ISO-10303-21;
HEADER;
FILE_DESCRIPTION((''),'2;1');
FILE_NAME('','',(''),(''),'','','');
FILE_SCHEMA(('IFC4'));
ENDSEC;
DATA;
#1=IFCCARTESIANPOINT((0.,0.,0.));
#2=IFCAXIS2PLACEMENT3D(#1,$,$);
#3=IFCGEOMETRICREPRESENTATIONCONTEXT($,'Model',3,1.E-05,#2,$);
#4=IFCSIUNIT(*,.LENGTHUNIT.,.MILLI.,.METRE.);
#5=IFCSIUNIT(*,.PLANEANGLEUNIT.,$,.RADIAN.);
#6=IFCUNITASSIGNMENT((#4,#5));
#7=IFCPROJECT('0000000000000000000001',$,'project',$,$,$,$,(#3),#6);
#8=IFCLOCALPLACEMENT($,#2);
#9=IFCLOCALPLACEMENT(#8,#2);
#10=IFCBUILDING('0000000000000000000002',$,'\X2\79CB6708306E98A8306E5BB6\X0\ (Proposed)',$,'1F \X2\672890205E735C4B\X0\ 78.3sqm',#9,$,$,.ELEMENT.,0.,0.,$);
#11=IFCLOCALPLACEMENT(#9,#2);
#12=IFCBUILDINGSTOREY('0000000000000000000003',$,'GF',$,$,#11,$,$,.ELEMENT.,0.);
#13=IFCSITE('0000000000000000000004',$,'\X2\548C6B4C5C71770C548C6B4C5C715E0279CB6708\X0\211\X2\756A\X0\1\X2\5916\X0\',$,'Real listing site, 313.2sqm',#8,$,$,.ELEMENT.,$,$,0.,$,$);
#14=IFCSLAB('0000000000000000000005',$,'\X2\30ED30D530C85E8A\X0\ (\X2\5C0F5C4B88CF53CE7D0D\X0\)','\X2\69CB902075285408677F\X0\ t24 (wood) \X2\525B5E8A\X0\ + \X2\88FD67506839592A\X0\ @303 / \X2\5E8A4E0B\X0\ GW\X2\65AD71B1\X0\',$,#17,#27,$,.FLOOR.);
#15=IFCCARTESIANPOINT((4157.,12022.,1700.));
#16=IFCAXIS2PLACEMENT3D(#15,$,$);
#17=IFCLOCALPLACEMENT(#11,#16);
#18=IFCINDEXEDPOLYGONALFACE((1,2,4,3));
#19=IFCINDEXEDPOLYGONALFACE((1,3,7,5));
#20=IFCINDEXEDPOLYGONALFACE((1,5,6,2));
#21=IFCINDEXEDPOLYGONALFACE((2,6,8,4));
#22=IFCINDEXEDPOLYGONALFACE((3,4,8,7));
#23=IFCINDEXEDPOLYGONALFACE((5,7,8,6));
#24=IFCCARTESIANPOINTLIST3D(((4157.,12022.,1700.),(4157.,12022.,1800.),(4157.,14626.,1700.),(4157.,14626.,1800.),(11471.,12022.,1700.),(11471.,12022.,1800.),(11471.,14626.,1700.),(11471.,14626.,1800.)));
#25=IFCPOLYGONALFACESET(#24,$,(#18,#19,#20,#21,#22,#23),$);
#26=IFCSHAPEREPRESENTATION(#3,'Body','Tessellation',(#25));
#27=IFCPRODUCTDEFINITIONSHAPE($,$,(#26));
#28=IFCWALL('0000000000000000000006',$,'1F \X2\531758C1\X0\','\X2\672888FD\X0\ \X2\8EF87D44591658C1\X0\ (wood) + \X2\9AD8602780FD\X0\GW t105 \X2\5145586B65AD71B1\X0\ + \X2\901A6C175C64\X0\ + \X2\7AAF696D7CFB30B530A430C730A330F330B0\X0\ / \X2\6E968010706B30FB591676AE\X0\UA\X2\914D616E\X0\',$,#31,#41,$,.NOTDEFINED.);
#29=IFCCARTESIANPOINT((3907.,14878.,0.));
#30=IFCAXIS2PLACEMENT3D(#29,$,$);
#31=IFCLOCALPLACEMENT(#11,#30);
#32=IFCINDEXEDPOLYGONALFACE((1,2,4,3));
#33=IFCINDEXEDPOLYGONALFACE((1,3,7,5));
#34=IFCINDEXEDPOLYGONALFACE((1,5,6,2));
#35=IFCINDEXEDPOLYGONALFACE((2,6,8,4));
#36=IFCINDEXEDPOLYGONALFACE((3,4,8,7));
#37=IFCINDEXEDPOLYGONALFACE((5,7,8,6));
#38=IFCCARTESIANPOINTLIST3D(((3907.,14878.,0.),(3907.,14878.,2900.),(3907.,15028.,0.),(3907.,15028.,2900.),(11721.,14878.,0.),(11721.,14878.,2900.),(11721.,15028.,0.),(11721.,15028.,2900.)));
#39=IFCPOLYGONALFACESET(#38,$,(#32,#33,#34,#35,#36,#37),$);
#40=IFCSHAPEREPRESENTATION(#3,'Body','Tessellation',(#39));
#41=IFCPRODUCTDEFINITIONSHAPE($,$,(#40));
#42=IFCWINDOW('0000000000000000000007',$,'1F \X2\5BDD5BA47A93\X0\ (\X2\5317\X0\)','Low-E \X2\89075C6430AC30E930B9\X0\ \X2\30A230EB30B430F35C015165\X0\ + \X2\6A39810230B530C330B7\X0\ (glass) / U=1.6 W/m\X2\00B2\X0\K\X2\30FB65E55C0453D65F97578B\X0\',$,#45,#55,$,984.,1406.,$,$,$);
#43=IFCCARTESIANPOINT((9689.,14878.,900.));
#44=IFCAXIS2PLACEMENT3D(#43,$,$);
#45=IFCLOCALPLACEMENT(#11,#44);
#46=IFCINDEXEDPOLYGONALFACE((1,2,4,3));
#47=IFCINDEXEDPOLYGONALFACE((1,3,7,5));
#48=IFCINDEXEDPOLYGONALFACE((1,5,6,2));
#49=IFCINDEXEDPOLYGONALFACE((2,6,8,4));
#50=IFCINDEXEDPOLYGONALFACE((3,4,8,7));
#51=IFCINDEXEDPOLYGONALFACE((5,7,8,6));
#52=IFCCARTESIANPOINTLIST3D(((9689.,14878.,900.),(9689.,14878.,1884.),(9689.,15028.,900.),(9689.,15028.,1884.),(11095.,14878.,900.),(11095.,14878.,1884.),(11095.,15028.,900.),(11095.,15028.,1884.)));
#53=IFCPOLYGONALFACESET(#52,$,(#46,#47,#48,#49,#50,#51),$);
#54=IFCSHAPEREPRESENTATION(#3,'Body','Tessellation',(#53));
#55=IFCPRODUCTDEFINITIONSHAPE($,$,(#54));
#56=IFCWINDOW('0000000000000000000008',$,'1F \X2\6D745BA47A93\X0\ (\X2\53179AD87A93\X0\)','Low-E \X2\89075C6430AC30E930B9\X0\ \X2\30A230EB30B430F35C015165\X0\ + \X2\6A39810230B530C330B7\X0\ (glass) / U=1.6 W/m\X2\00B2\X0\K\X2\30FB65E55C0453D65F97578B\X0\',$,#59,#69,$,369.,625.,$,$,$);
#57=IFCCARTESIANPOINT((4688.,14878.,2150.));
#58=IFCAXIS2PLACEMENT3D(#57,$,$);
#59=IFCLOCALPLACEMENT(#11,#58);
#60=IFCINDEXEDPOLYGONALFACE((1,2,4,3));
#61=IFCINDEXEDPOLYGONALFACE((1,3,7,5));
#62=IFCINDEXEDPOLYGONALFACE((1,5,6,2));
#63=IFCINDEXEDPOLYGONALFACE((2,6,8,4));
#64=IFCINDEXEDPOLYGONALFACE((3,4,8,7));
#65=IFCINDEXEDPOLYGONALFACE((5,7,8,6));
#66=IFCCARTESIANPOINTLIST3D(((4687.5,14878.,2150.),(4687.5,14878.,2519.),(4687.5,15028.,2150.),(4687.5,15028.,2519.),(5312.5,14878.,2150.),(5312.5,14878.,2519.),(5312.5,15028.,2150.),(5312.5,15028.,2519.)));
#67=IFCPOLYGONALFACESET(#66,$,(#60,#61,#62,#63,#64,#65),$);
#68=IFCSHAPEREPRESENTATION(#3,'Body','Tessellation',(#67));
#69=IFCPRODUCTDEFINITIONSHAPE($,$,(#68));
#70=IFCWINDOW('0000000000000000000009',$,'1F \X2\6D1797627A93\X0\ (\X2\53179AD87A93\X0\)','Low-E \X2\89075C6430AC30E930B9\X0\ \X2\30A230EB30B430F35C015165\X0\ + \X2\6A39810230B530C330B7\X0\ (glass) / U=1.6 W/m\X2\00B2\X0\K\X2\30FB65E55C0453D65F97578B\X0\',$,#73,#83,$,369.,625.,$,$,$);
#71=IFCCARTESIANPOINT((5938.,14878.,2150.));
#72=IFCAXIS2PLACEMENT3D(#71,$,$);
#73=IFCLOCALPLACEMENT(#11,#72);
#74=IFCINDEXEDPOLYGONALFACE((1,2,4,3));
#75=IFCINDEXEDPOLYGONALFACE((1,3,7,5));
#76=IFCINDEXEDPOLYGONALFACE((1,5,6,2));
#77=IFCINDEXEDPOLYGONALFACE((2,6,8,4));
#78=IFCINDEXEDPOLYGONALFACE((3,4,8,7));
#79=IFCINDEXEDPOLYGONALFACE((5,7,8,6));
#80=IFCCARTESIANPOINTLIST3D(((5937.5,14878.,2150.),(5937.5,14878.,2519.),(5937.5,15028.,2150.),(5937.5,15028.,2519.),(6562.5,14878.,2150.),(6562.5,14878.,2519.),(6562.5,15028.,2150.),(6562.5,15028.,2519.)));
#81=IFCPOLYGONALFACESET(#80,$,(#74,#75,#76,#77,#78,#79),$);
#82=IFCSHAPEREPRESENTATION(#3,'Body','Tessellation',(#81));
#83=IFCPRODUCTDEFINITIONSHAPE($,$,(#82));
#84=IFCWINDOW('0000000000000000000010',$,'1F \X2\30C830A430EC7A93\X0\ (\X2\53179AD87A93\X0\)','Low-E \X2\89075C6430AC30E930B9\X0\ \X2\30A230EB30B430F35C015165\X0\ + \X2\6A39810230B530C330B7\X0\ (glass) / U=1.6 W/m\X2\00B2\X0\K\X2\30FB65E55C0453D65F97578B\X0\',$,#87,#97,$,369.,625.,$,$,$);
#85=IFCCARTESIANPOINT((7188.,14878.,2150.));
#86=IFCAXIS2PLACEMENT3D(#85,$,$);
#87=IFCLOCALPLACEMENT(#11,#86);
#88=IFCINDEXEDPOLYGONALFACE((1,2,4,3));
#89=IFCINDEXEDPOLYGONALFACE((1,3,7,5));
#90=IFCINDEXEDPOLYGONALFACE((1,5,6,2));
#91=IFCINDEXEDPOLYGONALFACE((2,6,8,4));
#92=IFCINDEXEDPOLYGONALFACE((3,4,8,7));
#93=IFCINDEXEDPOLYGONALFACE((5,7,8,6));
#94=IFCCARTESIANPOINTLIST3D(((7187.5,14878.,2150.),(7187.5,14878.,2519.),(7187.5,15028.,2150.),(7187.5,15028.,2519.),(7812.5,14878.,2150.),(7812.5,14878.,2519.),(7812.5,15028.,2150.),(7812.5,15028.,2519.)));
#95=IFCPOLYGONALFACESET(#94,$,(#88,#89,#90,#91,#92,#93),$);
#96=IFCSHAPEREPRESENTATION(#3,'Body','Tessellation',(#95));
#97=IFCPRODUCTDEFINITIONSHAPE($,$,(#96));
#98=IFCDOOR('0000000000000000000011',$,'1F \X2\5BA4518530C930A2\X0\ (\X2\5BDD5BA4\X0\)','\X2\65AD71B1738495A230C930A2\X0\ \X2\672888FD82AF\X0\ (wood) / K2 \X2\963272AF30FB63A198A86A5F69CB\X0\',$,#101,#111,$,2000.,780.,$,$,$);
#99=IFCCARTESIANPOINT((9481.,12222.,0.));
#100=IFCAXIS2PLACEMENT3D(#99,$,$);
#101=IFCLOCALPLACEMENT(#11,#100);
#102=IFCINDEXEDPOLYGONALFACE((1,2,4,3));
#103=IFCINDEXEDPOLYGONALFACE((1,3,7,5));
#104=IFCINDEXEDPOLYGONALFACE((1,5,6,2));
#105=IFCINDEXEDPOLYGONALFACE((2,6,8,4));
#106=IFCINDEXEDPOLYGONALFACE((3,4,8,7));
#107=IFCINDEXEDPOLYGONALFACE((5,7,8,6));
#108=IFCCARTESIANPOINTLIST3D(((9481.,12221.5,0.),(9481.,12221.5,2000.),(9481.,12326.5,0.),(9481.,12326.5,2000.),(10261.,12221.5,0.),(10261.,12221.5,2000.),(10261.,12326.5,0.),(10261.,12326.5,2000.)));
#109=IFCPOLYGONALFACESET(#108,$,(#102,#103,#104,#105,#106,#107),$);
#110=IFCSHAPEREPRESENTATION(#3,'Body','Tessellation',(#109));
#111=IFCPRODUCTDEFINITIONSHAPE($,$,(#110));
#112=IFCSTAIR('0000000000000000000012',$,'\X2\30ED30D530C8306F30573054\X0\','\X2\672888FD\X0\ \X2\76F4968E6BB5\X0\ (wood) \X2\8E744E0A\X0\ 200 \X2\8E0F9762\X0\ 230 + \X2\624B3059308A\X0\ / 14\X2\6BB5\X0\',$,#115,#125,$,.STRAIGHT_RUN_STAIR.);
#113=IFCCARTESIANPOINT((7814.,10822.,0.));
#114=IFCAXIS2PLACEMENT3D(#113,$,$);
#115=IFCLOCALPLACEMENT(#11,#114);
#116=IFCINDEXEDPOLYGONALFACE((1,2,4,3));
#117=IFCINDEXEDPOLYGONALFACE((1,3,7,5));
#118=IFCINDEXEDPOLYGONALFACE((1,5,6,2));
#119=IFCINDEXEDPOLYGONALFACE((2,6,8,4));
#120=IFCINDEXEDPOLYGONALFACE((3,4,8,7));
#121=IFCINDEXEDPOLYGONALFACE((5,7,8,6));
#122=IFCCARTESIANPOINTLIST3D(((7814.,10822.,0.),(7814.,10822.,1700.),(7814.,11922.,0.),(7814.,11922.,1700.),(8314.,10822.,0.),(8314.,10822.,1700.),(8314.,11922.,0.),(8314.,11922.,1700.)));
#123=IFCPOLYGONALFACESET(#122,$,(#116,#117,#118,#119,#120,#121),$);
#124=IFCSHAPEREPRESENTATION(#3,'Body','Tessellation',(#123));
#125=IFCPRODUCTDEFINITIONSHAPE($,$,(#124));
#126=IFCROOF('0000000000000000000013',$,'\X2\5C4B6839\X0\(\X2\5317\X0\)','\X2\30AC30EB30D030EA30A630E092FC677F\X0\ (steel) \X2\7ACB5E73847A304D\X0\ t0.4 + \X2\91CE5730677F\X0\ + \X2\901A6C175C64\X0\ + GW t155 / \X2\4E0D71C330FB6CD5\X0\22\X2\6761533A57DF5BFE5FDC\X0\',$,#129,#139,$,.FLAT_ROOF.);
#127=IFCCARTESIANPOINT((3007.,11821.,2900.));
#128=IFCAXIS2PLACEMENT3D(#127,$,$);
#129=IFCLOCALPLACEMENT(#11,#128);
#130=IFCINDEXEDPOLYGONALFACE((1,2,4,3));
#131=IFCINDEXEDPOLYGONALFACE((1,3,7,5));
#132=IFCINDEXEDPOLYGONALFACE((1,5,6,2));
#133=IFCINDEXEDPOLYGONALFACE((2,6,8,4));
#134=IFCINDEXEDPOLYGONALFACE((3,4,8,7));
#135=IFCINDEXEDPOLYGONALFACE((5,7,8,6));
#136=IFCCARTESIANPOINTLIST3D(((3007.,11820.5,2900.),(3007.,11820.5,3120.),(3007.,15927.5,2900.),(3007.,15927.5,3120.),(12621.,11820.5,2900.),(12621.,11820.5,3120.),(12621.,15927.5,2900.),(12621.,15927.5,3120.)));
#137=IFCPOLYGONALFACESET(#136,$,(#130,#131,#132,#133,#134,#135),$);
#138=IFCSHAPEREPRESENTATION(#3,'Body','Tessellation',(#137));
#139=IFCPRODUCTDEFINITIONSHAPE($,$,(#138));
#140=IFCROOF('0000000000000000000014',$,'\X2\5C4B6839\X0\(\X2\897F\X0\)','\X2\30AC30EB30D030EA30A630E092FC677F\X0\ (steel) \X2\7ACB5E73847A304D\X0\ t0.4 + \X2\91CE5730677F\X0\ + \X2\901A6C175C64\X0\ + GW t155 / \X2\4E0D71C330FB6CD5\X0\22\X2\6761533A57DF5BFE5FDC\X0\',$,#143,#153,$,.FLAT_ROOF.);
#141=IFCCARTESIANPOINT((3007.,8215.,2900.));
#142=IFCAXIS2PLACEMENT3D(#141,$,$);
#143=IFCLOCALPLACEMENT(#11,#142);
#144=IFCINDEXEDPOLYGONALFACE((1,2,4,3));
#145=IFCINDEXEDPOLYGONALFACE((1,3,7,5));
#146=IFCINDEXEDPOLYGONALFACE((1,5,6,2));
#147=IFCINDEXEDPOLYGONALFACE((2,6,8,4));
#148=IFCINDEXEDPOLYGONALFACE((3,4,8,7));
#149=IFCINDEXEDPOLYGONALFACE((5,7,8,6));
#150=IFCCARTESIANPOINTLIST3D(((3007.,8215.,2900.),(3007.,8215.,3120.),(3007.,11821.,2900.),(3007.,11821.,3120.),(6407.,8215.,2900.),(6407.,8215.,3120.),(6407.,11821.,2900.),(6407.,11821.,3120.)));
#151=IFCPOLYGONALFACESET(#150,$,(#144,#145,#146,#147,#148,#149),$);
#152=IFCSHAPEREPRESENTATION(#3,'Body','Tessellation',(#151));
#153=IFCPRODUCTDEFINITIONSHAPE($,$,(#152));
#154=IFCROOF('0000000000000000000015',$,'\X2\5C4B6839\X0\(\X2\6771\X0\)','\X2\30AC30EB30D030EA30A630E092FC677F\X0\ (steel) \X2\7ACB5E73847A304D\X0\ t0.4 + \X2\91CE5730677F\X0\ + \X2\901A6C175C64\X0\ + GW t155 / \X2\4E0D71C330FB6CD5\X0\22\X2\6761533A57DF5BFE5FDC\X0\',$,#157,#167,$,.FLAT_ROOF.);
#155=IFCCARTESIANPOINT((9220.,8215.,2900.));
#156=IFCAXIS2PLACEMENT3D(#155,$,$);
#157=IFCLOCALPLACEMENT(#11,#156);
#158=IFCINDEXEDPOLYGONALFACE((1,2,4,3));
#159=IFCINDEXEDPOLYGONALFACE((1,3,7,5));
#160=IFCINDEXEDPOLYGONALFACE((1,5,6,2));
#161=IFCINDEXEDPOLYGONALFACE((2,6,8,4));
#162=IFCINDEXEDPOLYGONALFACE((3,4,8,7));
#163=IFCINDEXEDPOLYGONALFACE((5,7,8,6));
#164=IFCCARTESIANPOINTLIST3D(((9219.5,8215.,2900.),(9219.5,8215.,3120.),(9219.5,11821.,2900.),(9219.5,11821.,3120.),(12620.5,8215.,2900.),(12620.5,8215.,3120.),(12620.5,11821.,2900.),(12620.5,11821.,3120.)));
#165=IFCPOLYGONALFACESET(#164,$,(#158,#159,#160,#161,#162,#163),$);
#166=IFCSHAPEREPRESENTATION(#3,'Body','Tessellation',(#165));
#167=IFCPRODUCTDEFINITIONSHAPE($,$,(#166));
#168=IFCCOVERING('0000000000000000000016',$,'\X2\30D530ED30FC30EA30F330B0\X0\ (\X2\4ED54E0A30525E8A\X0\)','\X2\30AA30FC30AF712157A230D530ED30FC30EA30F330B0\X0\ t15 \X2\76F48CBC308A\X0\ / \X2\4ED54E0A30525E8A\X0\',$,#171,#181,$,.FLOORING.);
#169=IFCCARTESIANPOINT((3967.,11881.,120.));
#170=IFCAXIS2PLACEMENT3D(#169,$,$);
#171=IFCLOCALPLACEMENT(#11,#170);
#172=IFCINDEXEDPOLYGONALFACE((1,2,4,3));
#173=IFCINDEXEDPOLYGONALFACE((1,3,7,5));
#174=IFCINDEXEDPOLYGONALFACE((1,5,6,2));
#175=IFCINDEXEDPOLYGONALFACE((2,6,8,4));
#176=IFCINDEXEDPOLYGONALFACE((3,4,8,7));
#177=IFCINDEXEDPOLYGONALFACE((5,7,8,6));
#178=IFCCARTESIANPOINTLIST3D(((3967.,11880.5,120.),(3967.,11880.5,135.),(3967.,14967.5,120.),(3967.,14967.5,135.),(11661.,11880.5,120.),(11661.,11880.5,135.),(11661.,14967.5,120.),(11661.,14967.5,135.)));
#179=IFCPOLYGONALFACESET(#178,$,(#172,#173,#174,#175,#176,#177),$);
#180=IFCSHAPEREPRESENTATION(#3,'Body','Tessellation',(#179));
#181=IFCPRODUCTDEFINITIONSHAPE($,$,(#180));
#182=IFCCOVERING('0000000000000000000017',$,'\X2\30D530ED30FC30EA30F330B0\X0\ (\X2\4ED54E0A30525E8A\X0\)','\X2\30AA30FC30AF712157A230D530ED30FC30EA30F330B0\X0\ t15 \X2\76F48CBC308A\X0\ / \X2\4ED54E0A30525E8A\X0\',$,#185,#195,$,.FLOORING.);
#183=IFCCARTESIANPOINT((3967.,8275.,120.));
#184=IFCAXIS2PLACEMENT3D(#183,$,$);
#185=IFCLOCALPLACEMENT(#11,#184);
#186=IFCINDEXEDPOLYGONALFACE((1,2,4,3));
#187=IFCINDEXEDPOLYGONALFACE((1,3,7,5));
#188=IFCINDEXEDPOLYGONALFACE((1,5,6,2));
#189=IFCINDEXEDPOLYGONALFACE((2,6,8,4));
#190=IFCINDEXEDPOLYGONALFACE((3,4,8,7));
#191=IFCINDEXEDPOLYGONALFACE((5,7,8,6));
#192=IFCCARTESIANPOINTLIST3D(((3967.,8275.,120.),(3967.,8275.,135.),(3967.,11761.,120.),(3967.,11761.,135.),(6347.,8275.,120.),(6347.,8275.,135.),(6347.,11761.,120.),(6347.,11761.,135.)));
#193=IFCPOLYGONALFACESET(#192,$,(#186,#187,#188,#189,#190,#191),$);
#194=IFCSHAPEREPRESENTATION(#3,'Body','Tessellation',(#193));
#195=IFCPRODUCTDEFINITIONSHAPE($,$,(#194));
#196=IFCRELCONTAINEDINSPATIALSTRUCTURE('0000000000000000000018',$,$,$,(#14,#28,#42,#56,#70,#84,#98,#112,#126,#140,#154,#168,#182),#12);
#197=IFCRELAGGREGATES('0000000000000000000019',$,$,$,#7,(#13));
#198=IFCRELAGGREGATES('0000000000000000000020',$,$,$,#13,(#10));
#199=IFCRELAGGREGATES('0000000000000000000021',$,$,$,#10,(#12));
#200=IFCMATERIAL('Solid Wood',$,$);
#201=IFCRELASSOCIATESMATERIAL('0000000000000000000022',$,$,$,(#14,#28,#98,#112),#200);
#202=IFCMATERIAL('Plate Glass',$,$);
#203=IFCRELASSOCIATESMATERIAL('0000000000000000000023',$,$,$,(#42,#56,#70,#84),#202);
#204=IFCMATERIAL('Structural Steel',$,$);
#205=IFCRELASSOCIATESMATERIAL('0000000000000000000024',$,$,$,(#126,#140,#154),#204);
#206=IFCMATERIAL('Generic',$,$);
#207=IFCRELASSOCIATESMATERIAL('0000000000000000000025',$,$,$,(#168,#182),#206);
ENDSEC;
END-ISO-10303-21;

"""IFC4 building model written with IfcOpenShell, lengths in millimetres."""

from ifc_helpers import new_model, si_unit, frame, frame_2d, origin, place, context, project, spatial, rectangle, extrude, material, element, fill, save


model = new_model("IFC4")

# Units and contexts
model_context = context("Model", 3, precision=1e-05, world=origin())
ifc_project = project(units=[si_unit("LENGTHUNIT", "METRE", prefix="MILLI"), si_unit("PLANEANGLEUNIT", "RADIAN")], contexts=[model_context])

# Site, building, storey
site_placement = place(None, origin())
site = spatial("IfcSite", under=ifc_project, at=site_placement, Name="和歌山県和歌山市秋月211番1外", ObjectType="Real listing site, 313.2sqm", CompositionType="ELEMENT", RefElevation=0.0)
building_placement = place(site_placement, origin())
building = spatial("IfcBuilding", under=site, at=building_placement, Name="秋月の風の家 (Proposed)", ObjectType="1F 木造平屋 78.3sqm", CompositionType="ELEMENT", ElevationOfRefHeight=0.0, ElevationOfTerrain=0.0)
storey_placement = place(building_placement, origin())
storey = spatial("IfcBuildingStorey", under=building, at=storey_placement, Name="GF", CompositionType="ELEMENT", Elevation=0.0)

# Slab
ifc_material_1 = material(Name="Solid Wood")
slab_1_placement = place(storey_placement, frame((4157.0, 12022.0, 1700.0)))
element("IfcSlab", 1, at=slab_1_placement, inside=storey, material=ifc_material_1, Name="ロフト床 (小屋裏収納)", Description="構造用合板 t24 (wood) 剛床 + 製材根太 @303 / 床下 GW断熱", PredefinedType="FLOOR", context=model_context, shape_type="SweptSolid", body=[
    extrude(rectangle(XDim=7314.0, YDim=2604.0, at=frame_2d((3657.0, 1302.0))), frame((4157.0, 12022.0, 1700.0)), (0.0, 0.0, 1.0), 100.0),
])

# Wall, openings, windows
wall_1_placement = place(storey_placement, frame((3907.0, 14878.0, 0.0)))
wall_1 = element("IfcWall", 2, at=wall_1_placement, inside=storey, material=ifc_material_1, Name="1F 北壁", Description="木製 軸組外壁 (wood) + 高性能GW t105 充填断熱 + 通気層 + 窯業系サイディング / 準耐火・外皮UA配慮", PredefinedType="NOTDEFINED", context=model_context, shape_type="SweptSolid", body=[
    extrude(rectangle(XDim=7814.0, YDim=150.0, at=frame_2d((3907.0, 75.0))), frame((3907.0, 14878.0, 0.0)), (0.0, 0.0, 1.0), 2900.0),
])
opening_1_placement = place(storey_placement, frame((9689.0, 14878.0, 900.0)))
opening_1 = element("IfcOpeningElement", 3, at=opening_1_placement, cuts=wall_1, PredefinedType="NOTDEFINED", context=model_context, shape_type="SweptSolid", body=[
    extrude(rectangle(XDim=1406.0, YDim=150.0, at=frame_2d((703.0, 75.0))), frame((9689.0, 14878.0, 900.0)), (0.0, 0.0, 1.0), 984.0),
])
opening_2_placement = place(storey_placement, frame((4688.0, 14878.0, 2150.0)))
opening_2 = element("IfcOpeningElement", 4, at=opening_2_placement, cuts=wall_1, PredefinedType="NOTDEFINED", context=model_context, shape_type="SweptSolid", body=[
    extrude(rectangle(XDim=625.0, YDim=150.0, at=frame_2d((312.0, 75.0))), frame((4688.0, 14878.0, 2150.0)), (0.0, 0.0, 1.0), 369.0),
])
opening_3_placement = place(storey_placement, frame((5938.0, 14878.0, 2150.0)))
opening_3 = element("IfcOpeningElement", 5, at=opening_3_placement, cuts=wall_1, PredefinedType="NOTDEFINED", context=model_context, shape_type="SweptSolid", body=[
    extrude(rectangle(XDim=625.0, YDim=150.0, at=frame_2d((312.0, 75.0))), frame((5938.0, 14878.0, 2150.0)), (0.0, 0.0, 1.0), 369.0),
])
opening_4_placement = place(storey_placement, frame((7188.0, 14878.0, 2150.0)))
opening_4 = element("IfcOpeningElement", 6, at=opening_4_placement, cuts=wall_1, PredefinedType="NOTDEFINED", context=model_context, shape_type="SweptSolid", body=[
    extrude(rectangle(XDim=625.0, YDim=150.0, at=frame_2d((312.0, 75.0))), frame((7188.0, 14878.0, 2150.0)), (0.0, 0.0, 1.0), 369.0),
])
ifc_material_2 = material(Name="Plate Glass")
window_1_placement = place(storey_placement, frame((9689.0, 14878.0, 900.0)))
window_1 = element("IfcWindow", 7, at=window_1_placement, inside=storey, material=ifc_material_2, Name="1F 寝室窓 (北)", Description="Low-E 複層ガラス アルゴン封入 + 樹脂サッシ (glass) / U=1.6 W/m²K・日射取得型", OverallHeight=984.0, OverallWidth=1406.0, context=model_context, shape_type="SweptSolid", body=[
    extrude(rectangle(XDim=1406.0, YDim=150.0, at=frame_2d((703.0, 75.0))), frame((9689.0, 14878.0, 900.0)), (0.0, 0.0, 1.0), 984.0),
])
fill(opening_1, window_1)
window_2_placement = place(storey_placement, frame((4688.0, 14878.0, 2150.0)))
window_2 = element("IfcWindow", 8, at=window_2_placement, inside=storey, material=ifc_material_2, Name="1F 浴室窓 (北高窓)", Description="Low-E 複層ガラス アルゴン封入 + 樹脂サッシ (glass) / U=1.6 W/m²K・日射取得型", OverallHeight=369.0, OverallWidth=625.0, context=model_context, shape_type="SweptSolid", body=[
    extrude(rectangle(XDim=625.0, YDim=150.0, at=frame_2d((312.0, 75.0))), frame((4688.0, 14878.0, 2150.0)), (0.0, 0.0, 1.0), 369.0),
])
fill(opening_2, window_2)
window_3_placement = place(storey_placement, frame((5938.0, 14878.0, 2150.0)))
window_3 = element("IfcWindow", 9, at=window_3_placement, inside=storey, material=ifc_material_2, Name="1F 洗面窓 (北高窓)", Description="Low-E 複層ガラス アルゴン封入 + 樹脂サッシ (glass) / U=1.6 W/m²K・日射取得型", OverallHeight=369.0, OverallWidth=625.0, context=model_context, shape_type="SweptSolid", body=[
    extrude(rectangle(XDim=625.0, YDim=150.0, at=frame_2d((312.0, 75.0))), frame((5938.0, 14878.0, 2150.0)), (0.0, 0.0, 1.0), 369.0),
])
fill(opening_3, window_3)
window_4_placement = place(storey_placement, frame((7188.0, 14878.0, 2150.0)))
window_4 = element("IfcWindow", 10, at=window_4_placement, inside=storey, material=ifc_material_2, Name="1F トイレ窓 (北高窓)", Description="Low-E 複層ガラス アルゴン封入 + 樹脂サッシ (glass) / U=1.6 W/m²K・日射取得型", OverallHeight=369.0, OverallWidth=625.0, context=model_context, shape_type="SweptSolid", body=[
    extrude(rectangle(XDim=625.0, YDim=150.0, at=frame_2d((312.0, 75.0))), frame((7188.0, 14878.0, 2150.0)), (0.0, 0.0, 1.0), 369.0),
])
fill(opening_4, window_4)

# Door
door_1_placement = place(storey_placement, frame((9481.0, 12222.0, 0.0)))
element("IfcDoor", 11, at=door_1_placement, inside=storey, material=ifc_material_1, Name="1F 室内ドア (寝室)", Description="断熱玄関ドア 木製芯 (wood) / K2 防犯・採風機構", OverallHeight=2000.0, OverallWidth=780.0, context=model_context, shape_type="SweptSolid", body=[
    extrude(rectangle(XDim=780.0, YDim=105.0, at=frame_2d((390.0, 52.0))), frame((9481.0, 12222.0, 0.0)), (0.0, 0.0, 1.0), 2000.0),
])

# Stair
stair_placement = place(storey_placement, frame((7814.0, 10822.0, 0.0)))
element("IfcStair", 12, at=stair_placement, inside=storey, material=ifc_material_1, Name="ロフトはしご", Description="木製 直階段 (wood) 蹴上 200 踏面 230 + 手すり / 14段", PredefinedType="STRAIGHT_RUN_STAIR", context=model_context, shape_type="SweptSolid", body=[
    extrude(rectangle(XDim=500.0, YDim=1100.0, at=frame_2d((250.0, 550.0))), frame((7814.0, 10822.0, 0.0)), (0.0, 0.0, 1.0), 1700.0),
])

# Roofs
ifc_material_3 = material(Name="Structural Steel")
roof_1_placement = place(storey_placement, frame((3007.0, 11821.0, 2900.0)))
element("IfcRoof", 13, at=roof_1_placement, inside=storey, material=ifc_material_3, Name="屋根(北)", Description="ガルバリウム鋼板 (steel) 立平葺き t0.4 + 野地板 + 通気層 + GW t155 / 不燃・法22条区域対応", PredefinedType="FLAT_ROOF", context=model_context, shape_type="SweptSolid", body=[
    extrude(rectangle(XDim=9614.0, YDim=4107.0, at=frame_2d((4807.0, 2053.0))), frame((3007.0, 11821.0, 2900.0)), (0.0, 0.0, 1.0), 220.0),
])
roof_2_placement = place(storey_placement, frame((3007.0, 8215.0, 2900.0)))
element("IfcRoof", 14, at=roof_2_placement, inside=storey, material=ifc_material_3, Name="屋根(西)", Description="ガルバリウム鋼板 (steel) 立平葺き t0.4 + 野地板 + 通気層 + GW t155 / 不燃・法22条区域対応", PredefinedType="FLAT_ROOF", context=model_context, shape_type="SweptSolid", body=[
    extrude(rectangle(XDim=3400.0, YDim=3606.0, at=frame_2d((1700.0, 1803.0))), frame((3007.0, 8215.0, 2900.0)), (0.0, 0.0, 1.0), 220.0),
])
roof_3_placement = place(storey_placement, frame((9220.0, 8215.0, 2900.0)))
element("IfcRoof", 15, at=roof_3_placement, inside=storey, material=ifc_material_3, Name="屋根(東)", Description="ガルバリウム鋼板 (steel) 立平葺き t0.4 + 野地板 + 通気層 + GW t155 / 不燃・法22条区域対応", PredefinedType="FLAT_ROOF", context=model_context, shape_type="SweptSolid", body=[
    extrude(rectangle(XDim=3401.0, YDim=3606.0, at=frame_2d((1700.0, 1803.0))), frame((9220.0, 8215.0, 2900.0)), (0.0, 0.0, 1.0), 220.0),
])

# Coverings
ifc_material_4 = material(Name="Generic")
covering_1_placement = place(storey_placement, frame((3967.0, 11881.0, 120.0)))
element("IfcCovering", 16, at=covering_1_placement, inside=storey, material=ifc_material_4, Name="フローリング (仕上げ床)", Description="オーク無垢フローリング t15 直貼り / 仕上げ床", PredefinedType="FLOORING", context=model_context, shape_type="SweptSolid", body=[
    extrude(rectangle(XDim=7694.0, YDim=3087.0, at=frame_2d((3847.0, 1543.0))), frame((3967.0, 11881.0, 120.0)), (0.0, 0.0, 1.0), 15.0),
])
covering_2_placement = place(storey_placement, frame((3967.0, 8275.0, 120.0)))
element("IfcCovering", 17, at=covering_2_placement, inside=storey, material=ifc_material_4, Name="フローリング (仕上げ床)", Description="オーク無垢フローリング t15 直貼り / 仕上げ床", PredefinedType="FLOORING", context=model_context, shape_type="SweptSolid", body=[
    extrude(rectangle(XDim=2380.0, YDim=3486.0, at=frame_2d((1190.0, 1743.0))), frame((3967.0, 8275.0, 120.0)), (0.0, 0.0, 1.0), 15.0),
])

save(model, "model.ifc")
